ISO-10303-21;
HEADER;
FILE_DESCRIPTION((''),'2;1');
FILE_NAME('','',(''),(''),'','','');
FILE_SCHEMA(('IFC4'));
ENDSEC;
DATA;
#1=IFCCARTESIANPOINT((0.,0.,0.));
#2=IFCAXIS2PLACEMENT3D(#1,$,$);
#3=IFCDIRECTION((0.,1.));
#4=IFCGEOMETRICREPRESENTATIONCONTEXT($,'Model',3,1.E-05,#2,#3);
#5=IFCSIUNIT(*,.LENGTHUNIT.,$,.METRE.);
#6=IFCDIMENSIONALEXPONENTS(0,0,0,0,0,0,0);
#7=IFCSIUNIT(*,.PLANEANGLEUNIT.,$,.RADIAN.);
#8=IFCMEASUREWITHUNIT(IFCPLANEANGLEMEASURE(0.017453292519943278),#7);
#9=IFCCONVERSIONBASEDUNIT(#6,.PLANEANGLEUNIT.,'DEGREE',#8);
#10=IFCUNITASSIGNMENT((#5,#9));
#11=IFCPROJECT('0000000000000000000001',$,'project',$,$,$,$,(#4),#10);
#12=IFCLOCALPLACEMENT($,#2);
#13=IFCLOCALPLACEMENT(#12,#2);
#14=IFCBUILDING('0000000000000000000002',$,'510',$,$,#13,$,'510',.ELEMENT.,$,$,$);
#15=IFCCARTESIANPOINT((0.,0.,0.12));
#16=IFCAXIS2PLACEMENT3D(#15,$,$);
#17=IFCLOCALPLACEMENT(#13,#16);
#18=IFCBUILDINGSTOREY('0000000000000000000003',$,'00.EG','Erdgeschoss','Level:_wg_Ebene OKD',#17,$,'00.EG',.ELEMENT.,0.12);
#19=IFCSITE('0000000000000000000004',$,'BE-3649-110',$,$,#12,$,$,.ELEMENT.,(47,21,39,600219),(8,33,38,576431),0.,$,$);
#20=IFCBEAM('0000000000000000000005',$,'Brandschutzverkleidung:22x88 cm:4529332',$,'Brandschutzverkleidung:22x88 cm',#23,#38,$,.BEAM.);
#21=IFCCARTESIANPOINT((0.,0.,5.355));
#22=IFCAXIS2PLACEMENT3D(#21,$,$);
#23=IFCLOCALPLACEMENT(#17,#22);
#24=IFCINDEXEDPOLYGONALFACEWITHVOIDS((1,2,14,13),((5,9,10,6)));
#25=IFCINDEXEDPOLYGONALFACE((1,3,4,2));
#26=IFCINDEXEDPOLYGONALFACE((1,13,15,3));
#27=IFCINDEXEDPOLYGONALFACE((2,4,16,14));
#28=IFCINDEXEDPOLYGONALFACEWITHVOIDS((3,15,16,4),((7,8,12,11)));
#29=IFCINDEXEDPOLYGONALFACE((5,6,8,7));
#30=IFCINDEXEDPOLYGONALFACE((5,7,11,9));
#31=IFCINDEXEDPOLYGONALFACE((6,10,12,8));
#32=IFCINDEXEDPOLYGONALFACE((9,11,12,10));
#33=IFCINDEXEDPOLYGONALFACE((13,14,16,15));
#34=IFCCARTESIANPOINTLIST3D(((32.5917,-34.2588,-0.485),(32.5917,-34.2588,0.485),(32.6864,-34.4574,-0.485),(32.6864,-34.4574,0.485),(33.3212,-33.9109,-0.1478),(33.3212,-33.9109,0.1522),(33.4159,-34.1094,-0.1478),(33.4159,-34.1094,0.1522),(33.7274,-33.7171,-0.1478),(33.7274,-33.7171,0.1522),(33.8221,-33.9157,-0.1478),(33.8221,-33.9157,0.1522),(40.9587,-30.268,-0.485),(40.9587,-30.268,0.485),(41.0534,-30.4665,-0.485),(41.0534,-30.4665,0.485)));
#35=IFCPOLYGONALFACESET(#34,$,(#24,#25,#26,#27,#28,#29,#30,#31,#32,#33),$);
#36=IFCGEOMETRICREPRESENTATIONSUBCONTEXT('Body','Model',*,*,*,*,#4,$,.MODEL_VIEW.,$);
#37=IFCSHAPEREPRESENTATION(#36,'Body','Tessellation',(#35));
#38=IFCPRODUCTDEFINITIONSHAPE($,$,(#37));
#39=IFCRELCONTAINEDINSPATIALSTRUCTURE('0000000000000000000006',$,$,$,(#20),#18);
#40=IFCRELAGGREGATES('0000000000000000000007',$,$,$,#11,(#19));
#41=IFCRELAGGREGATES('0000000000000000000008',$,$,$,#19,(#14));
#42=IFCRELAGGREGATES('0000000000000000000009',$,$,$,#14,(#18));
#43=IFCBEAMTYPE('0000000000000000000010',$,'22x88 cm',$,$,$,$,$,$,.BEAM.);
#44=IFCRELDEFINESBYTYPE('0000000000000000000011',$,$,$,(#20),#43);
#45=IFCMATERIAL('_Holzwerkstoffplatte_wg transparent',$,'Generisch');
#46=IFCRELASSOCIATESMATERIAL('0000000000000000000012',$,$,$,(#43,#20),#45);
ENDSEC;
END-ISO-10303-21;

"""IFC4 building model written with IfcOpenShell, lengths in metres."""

from ifc_helpers import new_model, entity, si_unit, converted_unit, direction, frame, origin, place, context, subcontext, project, spatial, indexed_curve, outline, extrude, source, transform, mapped, material, type_object, type_shapes, element, save


model = new_model("IFC4")

# Units and contexts
model_context = context("Model", 3, precision=1e-05, world=origin(), true_north=direction((0.0, 1.0)))
body_context = subcontext(model_context, "Body", "Model", "MODEL_VIEW")
ifc_project = project(units=[si_unit("LENGTHUNIT", "METRE"), converted_unit("PLANEANGLEUNIT", "DEGREE", entity("IfcPlaneAngleMeasure", 0.017453292519943278), si_unit("PLANEANGLEUNIT", "RADIAN"), dimensions=[0, 0, 0, 0, 0, 0, 0])], contexts=[model_context])

# Site, building, storey
site_placement = place(None, origin())
site = spatial("IfcSite", under=ifc_project, at=site_placement, Name="BE-3649-110", CompositionType="ELEMENT", RefLatitude=(47, 21, 39, 600219), RefLongitude=(8, 33, 38, 576431), RefElevation=0.0)
building_placement = place(site_placement, origin())
building = spatial("IfcBuilding", under=site, at=building_placement, Name="510", LongName="510", CompositionType="ELEMENT")
storey_placement = place(building_placement, frame((0.0, 0.0, 0.12)))
storey = spatial("IfcBuildingStorey", under=building, at=storey_placement, Name="00.EG", Description="Erdgeschoss", ObjectType="Level:_wg_Ebene OKD", LongName="00.EG", CompositionType="ELEMENT", Elevation=0.12)

# Shared definitions
ifc_material_1 = material(Name="_Holzwerkstoffplatte_wg transparent", Category="Generisch")

# Beam
beam_type_1 = type_object("IfcBeamType", Name="22x88 cm", PredefinedType="BEAM", material=ifc_material_1)
shared_shape_1 = source(origin(), body_context, "Body", "SweptSolid", [
    extrude(outline(indexed_curve([(-4.635, -0.485), (4.635, -0.485), (4.635, 0.485), (-4.635, 0.485), (-4.635, -0.485)], self_intersect=False), holes=[indexed_curve([(-3.3767, 0.1478), (-3.3767, -0.1522), (-3.8267, -0.1522), (-3.8267, 0.1478), (-3.3767, 0.1478)], self_intersect=False)]), frame((36.8699, -32.462, 0.0), z_axis=(-0.430511, 0.902585, 0.0), x_axis=(0.902585, 0.430511, 0.0)), (0.0, 0.0, 1.0), 0.22),
])
type_shapes(beam_type_1, [shared_shape_1])
beam_1_placement = place(storey_placement, frame((0.0, 0.0, 5.355)))
element("IfcBeam", 1, at=beam_1_placement, inside=storey, type_object=beam_type_1, material=ifc_material_1, Name="Brandschutzverkleidung:22x88 cm:4529332", ObjectType="Brandschutzverkleidung:22x88 cm", PredefinedType="BEAM", context=body_context, shape_type="MappedRepresentation", body=[
    mapped(shared_shape_1, transform((0.0, 0.0, 0.0), scale=1.0)),
])

save(model, "model.ifc")
